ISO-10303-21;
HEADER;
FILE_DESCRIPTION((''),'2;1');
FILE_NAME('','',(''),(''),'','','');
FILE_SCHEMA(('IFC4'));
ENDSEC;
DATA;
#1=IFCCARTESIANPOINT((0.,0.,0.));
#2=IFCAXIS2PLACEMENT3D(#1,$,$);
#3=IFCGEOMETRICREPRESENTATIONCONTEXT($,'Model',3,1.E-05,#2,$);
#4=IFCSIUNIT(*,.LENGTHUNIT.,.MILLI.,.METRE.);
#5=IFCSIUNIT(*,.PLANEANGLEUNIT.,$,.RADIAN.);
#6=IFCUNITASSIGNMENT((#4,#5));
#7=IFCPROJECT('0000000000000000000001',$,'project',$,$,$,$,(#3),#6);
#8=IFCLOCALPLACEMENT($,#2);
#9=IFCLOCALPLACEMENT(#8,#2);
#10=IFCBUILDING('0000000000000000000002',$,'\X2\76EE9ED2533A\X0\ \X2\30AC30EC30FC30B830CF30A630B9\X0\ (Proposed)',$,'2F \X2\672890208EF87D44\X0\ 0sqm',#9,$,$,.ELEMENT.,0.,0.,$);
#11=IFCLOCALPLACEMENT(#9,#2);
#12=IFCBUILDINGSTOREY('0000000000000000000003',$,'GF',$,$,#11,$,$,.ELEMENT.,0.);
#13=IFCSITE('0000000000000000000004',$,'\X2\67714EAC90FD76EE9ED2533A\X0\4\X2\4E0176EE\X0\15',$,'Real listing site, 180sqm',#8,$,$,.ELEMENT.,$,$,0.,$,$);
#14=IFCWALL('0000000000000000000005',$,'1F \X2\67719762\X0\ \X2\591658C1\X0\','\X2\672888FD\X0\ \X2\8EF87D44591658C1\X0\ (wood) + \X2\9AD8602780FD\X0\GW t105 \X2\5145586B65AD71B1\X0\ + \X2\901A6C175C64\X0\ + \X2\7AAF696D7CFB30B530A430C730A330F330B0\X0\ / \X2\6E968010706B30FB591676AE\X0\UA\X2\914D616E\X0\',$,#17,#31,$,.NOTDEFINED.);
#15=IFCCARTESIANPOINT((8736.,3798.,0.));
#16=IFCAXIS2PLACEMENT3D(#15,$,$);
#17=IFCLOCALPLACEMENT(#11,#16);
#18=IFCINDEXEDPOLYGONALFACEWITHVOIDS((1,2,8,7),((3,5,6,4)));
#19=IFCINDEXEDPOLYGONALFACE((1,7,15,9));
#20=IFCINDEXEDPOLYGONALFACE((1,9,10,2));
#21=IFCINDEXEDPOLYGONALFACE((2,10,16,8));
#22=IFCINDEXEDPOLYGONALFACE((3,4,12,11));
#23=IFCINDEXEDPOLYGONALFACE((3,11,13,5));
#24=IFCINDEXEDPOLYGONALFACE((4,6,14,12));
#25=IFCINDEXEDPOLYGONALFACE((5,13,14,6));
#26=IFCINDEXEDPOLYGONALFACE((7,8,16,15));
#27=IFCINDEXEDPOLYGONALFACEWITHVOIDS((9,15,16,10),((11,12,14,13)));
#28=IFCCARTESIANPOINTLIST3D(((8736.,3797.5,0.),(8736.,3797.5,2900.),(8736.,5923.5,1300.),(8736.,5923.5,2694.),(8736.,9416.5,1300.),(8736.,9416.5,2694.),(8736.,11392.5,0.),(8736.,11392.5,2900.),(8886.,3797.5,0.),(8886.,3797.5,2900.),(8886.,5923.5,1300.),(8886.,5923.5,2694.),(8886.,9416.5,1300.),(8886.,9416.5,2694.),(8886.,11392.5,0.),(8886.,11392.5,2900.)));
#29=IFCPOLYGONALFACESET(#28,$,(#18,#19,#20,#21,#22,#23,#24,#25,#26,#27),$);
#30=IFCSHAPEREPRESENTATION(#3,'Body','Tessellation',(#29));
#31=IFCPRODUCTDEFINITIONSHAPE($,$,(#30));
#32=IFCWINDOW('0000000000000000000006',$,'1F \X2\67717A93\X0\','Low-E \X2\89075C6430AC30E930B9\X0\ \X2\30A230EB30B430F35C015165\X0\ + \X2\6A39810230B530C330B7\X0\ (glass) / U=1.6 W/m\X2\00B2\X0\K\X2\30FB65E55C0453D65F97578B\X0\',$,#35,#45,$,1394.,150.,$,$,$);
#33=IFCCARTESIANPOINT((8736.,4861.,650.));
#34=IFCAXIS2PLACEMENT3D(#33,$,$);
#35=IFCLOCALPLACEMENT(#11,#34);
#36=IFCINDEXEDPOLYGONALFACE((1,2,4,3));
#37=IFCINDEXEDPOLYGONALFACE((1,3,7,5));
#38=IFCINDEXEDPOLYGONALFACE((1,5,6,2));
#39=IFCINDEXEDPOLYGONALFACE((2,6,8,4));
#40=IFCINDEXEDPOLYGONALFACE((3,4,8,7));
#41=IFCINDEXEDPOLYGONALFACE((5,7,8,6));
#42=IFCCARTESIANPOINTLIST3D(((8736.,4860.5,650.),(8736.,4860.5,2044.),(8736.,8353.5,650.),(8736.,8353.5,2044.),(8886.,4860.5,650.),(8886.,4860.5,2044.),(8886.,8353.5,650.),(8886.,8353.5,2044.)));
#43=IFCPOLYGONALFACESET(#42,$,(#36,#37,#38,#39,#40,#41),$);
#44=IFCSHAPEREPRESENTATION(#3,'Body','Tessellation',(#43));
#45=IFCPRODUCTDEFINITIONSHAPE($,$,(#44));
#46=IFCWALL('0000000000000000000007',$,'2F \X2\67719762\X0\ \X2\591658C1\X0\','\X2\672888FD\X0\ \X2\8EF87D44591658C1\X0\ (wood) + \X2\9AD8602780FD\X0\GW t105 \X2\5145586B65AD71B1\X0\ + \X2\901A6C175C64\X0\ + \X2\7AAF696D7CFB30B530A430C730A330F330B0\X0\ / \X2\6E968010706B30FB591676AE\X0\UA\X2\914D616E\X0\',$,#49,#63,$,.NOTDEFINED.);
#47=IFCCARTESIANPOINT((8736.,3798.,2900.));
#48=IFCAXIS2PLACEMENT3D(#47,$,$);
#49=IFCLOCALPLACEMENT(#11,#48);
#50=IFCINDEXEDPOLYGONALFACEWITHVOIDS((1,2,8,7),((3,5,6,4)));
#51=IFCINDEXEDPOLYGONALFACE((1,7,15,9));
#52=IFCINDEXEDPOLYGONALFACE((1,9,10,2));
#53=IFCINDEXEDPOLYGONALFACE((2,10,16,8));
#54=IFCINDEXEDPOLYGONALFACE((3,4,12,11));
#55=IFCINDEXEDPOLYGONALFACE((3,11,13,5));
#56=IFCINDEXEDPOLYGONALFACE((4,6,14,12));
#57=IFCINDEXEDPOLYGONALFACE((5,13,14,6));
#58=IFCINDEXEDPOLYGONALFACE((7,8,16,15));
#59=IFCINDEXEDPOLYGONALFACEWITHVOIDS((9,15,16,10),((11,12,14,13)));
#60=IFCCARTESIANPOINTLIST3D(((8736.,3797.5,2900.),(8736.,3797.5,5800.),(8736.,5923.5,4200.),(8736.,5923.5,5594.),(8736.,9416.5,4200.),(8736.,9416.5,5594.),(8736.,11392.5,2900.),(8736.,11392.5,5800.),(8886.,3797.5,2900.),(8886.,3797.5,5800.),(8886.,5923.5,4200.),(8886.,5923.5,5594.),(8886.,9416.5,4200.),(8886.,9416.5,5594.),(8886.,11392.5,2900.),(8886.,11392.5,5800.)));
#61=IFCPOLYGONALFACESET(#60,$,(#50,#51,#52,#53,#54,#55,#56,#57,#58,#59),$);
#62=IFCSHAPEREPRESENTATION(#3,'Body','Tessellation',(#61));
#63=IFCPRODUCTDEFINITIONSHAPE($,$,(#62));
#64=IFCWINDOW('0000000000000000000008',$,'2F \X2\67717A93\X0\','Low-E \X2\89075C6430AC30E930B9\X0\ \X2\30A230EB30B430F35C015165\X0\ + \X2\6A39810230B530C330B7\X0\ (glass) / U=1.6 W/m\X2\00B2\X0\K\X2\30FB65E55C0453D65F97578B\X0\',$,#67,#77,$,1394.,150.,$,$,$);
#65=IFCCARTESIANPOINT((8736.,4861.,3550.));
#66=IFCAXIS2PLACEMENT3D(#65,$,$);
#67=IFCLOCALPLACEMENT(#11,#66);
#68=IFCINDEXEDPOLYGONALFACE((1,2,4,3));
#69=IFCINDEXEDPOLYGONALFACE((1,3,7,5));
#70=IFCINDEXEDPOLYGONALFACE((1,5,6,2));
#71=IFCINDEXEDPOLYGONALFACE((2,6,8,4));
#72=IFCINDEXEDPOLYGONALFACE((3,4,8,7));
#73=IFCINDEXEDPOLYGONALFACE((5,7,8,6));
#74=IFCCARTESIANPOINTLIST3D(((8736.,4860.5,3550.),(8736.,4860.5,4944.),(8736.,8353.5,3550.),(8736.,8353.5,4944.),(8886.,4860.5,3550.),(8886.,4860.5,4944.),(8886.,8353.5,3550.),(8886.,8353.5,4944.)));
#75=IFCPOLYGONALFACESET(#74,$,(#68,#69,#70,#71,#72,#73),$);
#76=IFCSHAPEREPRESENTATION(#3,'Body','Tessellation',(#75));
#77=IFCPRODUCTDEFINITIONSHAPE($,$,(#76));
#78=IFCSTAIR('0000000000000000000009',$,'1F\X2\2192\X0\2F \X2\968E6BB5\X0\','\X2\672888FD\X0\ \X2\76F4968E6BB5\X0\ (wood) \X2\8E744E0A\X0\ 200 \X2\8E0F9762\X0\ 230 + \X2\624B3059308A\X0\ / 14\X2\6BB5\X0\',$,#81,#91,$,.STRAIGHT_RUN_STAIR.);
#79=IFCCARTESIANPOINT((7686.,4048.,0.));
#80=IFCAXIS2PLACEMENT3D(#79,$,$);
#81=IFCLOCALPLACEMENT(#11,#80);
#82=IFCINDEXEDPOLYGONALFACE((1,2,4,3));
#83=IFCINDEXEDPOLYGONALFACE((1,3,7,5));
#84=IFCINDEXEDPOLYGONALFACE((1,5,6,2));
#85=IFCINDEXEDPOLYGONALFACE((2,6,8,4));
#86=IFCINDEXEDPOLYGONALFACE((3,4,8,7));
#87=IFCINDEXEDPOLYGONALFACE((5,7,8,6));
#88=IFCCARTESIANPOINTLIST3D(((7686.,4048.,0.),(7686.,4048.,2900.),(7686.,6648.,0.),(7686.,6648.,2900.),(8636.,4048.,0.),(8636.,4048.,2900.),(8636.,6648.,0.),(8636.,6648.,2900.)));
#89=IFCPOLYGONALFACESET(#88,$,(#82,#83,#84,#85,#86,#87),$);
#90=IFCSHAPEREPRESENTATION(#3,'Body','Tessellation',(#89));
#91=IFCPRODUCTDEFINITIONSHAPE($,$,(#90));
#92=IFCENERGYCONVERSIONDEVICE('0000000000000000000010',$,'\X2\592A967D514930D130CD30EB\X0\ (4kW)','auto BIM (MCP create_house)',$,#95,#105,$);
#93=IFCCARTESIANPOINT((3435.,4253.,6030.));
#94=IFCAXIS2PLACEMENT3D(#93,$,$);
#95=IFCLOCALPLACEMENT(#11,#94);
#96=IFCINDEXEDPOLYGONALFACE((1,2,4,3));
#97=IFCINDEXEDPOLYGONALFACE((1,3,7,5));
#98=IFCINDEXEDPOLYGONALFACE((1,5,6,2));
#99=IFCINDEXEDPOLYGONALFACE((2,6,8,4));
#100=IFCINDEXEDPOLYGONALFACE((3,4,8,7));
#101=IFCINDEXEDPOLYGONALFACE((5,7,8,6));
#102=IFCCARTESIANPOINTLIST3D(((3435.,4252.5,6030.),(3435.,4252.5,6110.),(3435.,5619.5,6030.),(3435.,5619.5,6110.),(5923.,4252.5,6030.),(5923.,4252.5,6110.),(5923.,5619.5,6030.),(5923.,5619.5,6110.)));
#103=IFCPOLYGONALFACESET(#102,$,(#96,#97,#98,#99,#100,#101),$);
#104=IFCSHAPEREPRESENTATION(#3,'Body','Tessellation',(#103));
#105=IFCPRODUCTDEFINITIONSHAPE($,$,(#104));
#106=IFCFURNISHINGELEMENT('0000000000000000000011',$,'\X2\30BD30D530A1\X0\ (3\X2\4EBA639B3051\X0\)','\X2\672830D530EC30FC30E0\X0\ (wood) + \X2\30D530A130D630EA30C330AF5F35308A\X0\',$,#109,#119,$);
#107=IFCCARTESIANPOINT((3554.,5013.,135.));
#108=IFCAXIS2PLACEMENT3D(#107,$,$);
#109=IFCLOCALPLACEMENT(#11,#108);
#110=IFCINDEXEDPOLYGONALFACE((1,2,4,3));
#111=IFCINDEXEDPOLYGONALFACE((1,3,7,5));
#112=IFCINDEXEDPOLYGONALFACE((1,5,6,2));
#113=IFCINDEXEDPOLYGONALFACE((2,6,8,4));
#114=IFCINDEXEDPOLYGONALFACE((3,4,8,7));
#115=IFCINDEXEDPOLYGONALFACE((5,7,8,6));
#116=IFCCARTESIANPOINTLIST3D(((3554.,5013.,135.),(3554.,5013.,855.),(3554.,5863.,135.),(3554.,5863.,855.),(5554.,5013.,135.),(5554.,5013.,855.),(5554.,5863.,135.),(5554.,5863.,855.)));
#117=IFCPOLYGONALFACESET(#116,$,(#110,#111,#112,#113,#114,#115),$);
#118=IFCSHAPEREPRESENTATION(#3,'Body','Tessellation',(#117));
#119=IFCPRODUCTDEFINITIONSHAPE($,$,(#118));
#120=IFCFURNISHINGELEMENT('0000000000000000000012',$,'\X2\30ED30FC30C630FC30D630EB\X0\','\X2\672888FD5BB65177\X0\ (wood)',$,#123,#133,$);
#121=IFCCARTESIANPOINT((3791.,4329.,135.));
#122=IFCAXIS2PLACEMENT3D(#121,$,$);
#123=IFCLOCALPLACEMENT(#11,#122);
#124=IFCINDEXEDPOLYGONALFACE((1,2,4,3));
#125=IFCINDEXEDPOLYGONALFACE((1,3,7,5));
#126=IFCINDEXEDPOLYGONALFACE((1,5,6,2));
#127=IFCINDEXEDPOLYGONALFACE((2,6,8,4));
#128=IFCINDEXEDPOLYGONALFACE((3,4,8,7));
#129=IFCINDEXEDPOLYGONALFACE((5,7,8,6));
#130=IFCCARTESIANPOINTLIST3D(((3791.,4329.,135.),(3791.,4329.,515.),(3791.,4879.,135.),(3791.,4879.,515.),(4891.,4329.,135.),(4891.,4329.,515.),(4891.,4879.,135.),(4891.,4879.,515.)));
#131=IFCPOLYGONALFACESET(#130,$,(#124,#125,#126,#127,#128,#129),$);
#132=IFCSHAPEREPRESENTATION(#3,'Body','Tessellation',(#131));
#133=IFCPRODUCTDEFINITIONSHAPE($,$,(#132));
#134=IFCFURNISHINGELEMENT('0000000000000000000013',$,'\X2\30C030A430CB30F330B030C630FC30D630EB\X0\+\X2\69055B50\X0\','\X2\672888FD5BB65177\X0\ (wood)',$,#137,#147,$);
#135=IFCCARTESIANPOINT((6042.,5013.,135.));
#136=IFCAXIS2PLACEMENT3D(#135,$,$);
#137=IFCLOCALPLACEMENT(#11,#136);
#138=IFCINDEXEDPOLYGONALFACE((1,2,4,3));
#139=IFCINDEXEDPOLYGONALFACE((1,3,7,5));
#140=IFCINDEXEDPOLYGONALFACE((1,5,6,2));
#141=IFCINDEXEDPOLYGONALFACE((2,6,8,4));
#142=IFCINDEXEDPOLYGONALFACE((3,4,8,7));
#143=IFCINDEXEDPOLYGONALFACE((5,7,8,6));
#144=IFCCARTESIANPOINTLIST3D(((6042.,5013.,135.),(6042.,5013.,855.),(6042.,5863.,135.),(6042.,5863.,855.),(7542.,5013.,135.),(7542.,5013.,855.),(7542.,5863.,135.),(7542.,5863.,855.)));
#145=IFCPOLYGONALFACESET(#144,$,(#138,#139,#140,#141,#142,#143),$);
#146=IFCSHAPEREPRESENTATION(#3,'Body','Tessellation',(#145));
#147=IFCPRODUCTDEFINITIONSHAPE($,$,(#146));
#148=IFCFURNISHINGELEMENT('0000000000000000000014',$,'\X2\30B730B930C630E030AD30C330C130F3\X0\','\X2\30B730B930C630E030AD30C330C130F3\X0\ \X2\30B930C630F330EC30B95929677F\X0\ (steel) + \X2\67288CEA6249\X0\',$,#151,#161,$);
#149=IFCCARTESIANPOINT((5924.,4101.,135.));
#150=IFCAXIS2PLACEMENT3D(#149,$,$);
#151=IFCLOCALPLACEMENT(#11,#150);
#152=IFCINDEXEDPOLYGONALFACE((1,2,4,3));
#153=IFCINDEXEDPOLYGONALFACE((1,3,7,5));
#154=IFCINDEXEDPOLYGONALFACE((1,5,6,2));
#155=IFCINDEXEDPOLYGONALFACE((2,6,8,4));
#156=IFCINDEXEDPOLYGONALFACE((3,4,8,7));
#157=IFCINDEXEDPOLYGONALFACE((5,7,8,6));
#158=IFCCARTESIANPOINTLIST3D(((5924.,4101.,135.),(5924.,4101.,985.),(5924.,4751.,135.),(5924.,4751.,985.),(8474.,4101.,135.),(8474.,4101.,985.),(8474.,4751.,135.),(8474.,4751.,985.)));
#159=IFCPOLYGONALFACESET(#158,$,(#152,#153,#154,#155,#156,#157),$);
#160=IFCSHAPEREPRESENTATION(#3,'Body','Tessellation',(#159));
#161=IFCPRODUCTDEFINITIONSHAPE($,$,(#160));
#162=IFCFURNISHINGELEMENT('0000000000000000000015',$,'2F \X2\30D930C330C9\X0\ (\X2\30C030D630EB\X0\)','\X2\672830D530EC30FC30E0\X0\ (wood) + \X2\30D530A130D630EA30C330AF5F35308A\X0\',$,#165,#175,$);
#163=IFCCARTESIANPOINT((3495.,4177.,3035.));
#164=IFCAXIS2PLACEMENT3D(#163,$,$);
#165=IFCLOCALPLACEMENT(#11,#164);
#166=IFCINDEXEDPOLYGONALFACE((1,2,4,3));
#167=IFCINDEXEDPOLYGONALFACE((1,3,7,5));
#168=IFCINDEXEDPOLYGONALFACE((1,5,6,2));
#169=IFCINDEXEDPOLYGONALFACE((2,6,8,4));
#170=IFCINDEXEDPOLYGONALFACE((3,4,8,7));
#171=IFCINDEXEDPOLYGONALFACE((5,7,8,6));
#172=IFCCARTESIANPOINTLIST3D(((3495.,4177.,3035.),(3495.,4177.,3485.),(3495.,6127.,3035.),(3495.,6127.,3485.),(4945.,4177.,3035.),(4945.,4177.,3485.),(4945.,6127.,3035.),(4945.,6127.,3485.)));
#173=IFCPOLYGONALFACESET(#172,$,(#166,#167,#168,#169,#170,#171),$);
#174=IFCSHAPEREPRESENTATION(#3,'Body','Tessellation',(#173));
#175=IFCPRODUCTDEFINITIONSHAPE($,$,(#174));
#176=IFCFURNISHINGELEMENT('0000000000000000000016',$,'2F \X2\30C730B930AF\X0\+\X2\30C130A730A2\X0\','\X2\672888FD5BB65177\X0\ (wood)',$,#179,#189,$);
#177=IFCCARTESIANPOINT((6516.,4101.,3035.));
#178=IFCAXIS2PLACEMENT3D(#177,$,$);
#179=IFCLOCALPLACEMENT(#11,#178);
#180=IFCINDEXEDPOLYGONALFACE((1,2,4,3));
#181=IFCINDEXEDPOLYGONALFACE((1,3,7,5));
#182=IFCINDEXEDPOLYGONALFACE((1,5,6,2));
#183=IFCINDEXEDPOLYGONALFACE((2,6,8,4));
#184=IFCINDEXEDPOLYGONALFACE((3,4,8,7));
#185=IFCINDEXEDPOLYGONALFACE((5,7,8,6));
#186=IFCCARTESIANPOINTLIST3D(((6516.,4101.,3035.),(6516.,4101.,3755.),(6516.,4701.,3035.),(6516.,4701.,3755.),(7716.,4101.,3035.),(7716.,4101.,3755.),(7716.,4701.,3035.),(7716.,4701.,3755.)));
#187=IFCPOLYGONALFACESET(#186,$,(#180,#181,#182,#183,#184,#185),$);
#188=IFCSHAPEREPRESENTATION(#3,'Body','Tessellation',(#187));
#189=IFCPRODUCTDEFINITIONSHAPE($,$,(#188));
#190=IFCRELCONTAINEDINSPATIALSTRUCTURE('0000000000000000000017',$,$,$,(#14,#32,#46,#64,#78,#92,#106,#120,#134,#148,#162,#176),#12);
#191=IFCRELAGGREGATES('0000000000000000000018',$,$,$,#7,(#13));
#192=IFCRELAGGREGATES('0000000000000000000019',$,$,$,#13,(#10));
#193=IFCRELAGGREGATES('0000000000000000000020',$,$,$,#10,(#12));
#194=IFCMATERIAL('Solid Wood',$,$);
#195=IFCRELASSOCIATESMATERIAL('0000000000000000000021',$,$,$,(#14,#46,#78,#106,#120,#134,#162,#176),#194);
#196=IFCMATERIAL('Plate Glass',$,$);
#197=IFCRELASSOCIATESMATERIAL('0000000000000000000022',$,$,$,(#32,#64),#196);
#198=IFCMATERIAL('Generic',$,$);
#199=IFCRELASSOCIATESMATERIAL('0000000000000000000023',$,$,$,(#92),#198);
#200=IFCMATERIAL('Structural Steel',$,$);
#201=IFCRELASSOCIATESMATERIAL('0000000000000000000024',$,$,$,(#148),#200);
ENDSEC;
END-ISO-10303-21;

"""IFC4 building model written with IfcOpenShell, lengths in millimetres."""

from ifc_helpers import new_model, si_unit, frame, frame_2d, origin, place, context, project, spatial, rectangle, extrude, material, element, fill, save


model = new_model("IFC4")

# Units and contexts
model_context = context("Model", 3, precision=1e-05, world=origin())
ifc_project = project(units=[si_unit("LENGTHUNIT", "METRE", prefix="MILLI"), si_unit("PLANEANGLEUNIT", "RADIAN")], contexts=[model_context])

# Site, building, storey
site_placement = place(None, origin())
site = spatial("IfcSite", under=ifc_project, at=site_placement, Name="東京都目黒区4丁目15", ObjectType="Real listing site, 180sqm", CompositionType="ELEMENT", RefElevation=0.0)
building_placement = place(site_placement, origin())
building = spatial("IfcBuilding", under=site, at=building_placement, Name="目黒区 ガレージハウス (Proposed)", ObjectType="2F 木造軸組 0sqm", CompositionType="ELEMENT", ElevationOfRefHeight=0.0, ElevationOfTerrain=0.0)
storey_placement = place(building_placement, origin())
storey = spatial("IfcBuildingStorey", under=building, at=storey_placement, Name="GF", CompositionType="ELEMENT", Elevation=0.0)

# Wall, opening, window
ifc_material_1 = material(Name="Solid Wood")
wall_1_placement = place(storey_placement, frame((8736.0, 3798.0, 0.0)))
wall_1 = element("IfcWall", 1, at=wall_1_placement, inside=storey, material=ifc_material_1, Name="1F 東面 外壁", Description="木製 軸組外壁 (wood) + 高性能GW t105 充填断熱 + 通気層 + 窯業系サイディング / 準耐火・外皮UA配慮", PredefinedType="NOTDEFINED", context=model_context, shape_type="SweptSolid", body=[
    extrude(rectangle(XDim=150.0, YDim=7595.0, at=frame_2d((75.0, 3797.0))), frame((8736.0, 3798.0, 0.0)), (0.0, 0.0, 1.0), 2900.0),
])
opening_1_placement = place(storey_placement, frame((8736.0, 4861.0, 650.0)))
opening_1 = element("IfcOpeningElement", 2, at=opening_1_placement, cuts=wall_1, PredefinedType="NOTDEFINED", context=model_context, shape_type="SweptSolid", body=[
    extrude(rectangle(XDim=150.0, YDim=3493.0, at=frame_2d((75.0, 1746.0))), frame((8736.0, 4861.0, 650.0)), (0.0, 0.0, 1.0), 1394.0),
])
ifc_material_2 = material(Name="Plate Glass")
window_1_placement = place(storey_placement, frame((8736.0, 4861.0, 650.0)))
window_1 = element("IfcWindow", 3, at=window_1_placement, inside=storey, material=ifc_material_2, Name="1F 東窓", Description="Low-E 複層ガラス アルゴン封入 + 樹脂サッシ (glass) / U=1.6 W/m²K・日射取得型", OverallHeight=1394.0, OverallWidth=150.0, context=model_context, shape_type="SweptSolid", body=[
    extrude(rectangle(XDim=150.0, YDim=3493.0, at=frame_2d((75.0, 1746.0))), frame((8736.0, 4861.0, 650.0)), (0.0, 0.0, 1.0), 1394.0),
])
fill(opening_1, window_1)

# Wall, opening, window
wall_2_placement = place(storey_placement, frame((8736.0, 3798.0, 2900.0)))
wall_2 = element("IfcWall", 4, at=wall_2_placement, inside=storey, material=ifc_material_1, Name="2F 東面 外壁", Description="木製 軸組外壁 (wood) + 高性能GW t105 充填断熱 + 通気層 + 窯業系サイディング / 準耐火・外皮UA配慮", PredefinedType="NOTDEFINED", context=model_context, shape_type="SweptSolid", body=[
    extrude(rectangle(XDim=150.0, YDim=7595.0, at=frame_2d((75.0, 3797.0))), frame((8736.0, 3798.0, 2900.0)), (0.0, 0.0, 1.0), 2900.0),
])
opening_2_placement = place(storey_placement, frame((8736.0, 4861.0, 3550.0)))
opening_2 = element("IfcOpeningElement", 5, at=opening_2_placement, cuts=wall_2, PredefinedType="NOTDEFINED", context=model_context, shape_type="SweptSolid", body=[
    extrude(rectangle(XDim=150.0, YDim=3493.0, at=frame_2d((75.0, 1746.0))), frame((8736.0, 4861.0, 3550.0)), (0.0, 0.0, 1.0), 1394.0),
])
window_2_placement = place(storey_placement, frame((8736.0, 4861.0, 3550.0)))
window_2 = element("IfcWindow", 6, at=window_2_placement, inside=storey, material=ifc_material_2, Name="2F 東窓", Description="Low-E 複層ガラス アルゴン封入 + 樹脂サッシ (glass) / U=1.6 W/m²K・日射取得型", OverallHeight=1394.0, OverallWidth=150.0, context=model_context, shape_type="SweptSolid", body=[
    extrude(rectangle(XDim=150.0, YDim=3493.0, at=frame_2d((75.0, 1746.0))), frame((8736.0, 4861.0, 3550.0)), (0.0, 0.0, 1.0), 1394.0),
])
fill(opening_2, window_2)

# Stair
stair_placement = place(storey_placement, frame((7686.0, 4048.0, 0.0)))
element("IfcStair", 7, at=stair_placement, inside=storey, material=ifc_material_1, Name="1F→2F 階段", Description="木製 直階段 (wood) 蹴上 200 踏面 230 + 手すり / 14段", PredefinedType="STRAIGHT_RUN_STAIR", context=model_context, shape_type="SweptSolid", body=[
    extrude(rectangle(XDim=950.0, YDim=2600.0, at=frame_2d((475.0, 1300.0))), frame((7686.0, 4048.0, 0.0)), (0.0, 0.0, 1.0), 2900.0),
])

# Energy conversion device
ifc_material_3 = material(Name="Generic")
energy_conversion_device_placement = place(storey_placement, frame((3435.0, 4253.0, 6030.0)))
element("IfcEnergyConversionDevice", 8, at=energy_conversion_device_placement, inside=storey, material=ifc_material_3, Name="太陽光パネル (4kW)", Description="auto BIM (MCP create_house)", context=model_context, shape_type="SweptSolid", body=[
    extrude(rectangle(XDim=2488.0, YDim=1367.0, at=frame_2d((1244.0, 683.0))), frame((3435.0, 4253.0, 6030.0)), (0.0, 0.0, 1.0), 80.0),
])

# Furnishing elements
furnishing_1_placement = place(storey_placement, frame((3554.0, 5013.0, 135.0)))
element("IfcFurnishingElement", 9, at=furnishing_1_placement, inside=storey, material=ifc_material_1, Name="ソファ (3人掛け)", Description="木フレーム (wood) + ファブリック張り", context=model_context, shape_type="SweptSolid", body=[
    extrude(rectangle(XDim=2000.0, YDim=850.0, at=frame_2d((1000.0, 425.0))), frame((3554.0, 5013.0, 135.0)), (0.0, 0.0, 1.0), 720.0),
])
furnishing_2_placement = place(storey_placement, frame((3791.0, 4329.0, 135.0)))
element("IfcFurnishingElement", 10, at=furnishing_2_placement, inside=storey, material=ifc_material_1, Name="ローテーブル", Description="木製家具 (wood)", context=model_context, shape_type="SweptSolid", body=[
    extrude(rectangle(XDim=1100.0, YDim=550.0, at=frame_2d((550.0, 275.0))), frame((3791.0, 4329.0, 135.0)), (0.0, 0.0, 1.0), 380.0),
])
furnishing_3_placement = place(storey_placement, frame((6042.0, 5013.0, 135.0)))
element("IfcFurnishingElement", 11, at=furnishing_3_placement, inside=storey, material=ifc_material_1, Name="ダイニングテーブル+椅子", Description="木製家具 (wood)", context=model_context, shape_type="SweptSolid", body=[
    extrude(rectangle(XDim=1500.0, YDim=850.0, at=frame_2d((750.0, 425.0))), frame((6042.0, 5013.0, 135.0)), (0.0, 0.0, 1.0), 720.0),
])
ifc_material_4 = material(Name="Structural Steel")
furnishing_4_placement = place(storey_placement, frame((5924.0, 4101.0, 135.0)))
element("IfcFurnishingElement", 12, at=furnishing_4_placement, inside=storey, material=ifc_material_4, Name="システムキッチン", Description="システムキッチン ステンレス天板 (steel) + 木質扉", context=model_context, shape_type="SweptSolid", body=[
    extrude(rectangle(XDim=2550.0, YDim=650.0, at=frame_2d((1275.0, 325.0))), frame((5924.0, 4101.0, 135.0)), (0.0, 0.0, 1.0), 850.0),
])
furnishing_5_placement = place(storey_placement, frame((3495.0, 4177.0, 3035.0)))
element("IfcFurnishingElement", 13, at=furnishing_5_placement, inside=storey, material=ifc_material_1, Name="2F ベッド (ダブル)", Description="木フレーム (wood) + ファブリック張り", context=model_context, shape_type="SweptSolid", body=[
    extrude(rectangle(XDim=1450.0, YDim=1950.0, at=frame_2d((725.0, 975.0))), frame((3495.0, 4177.0, 3035.0)), (0.0, 0.0, 1.0), 450.0),
])
furnishing_6_placement = place(storey_placement, frame((6516.0, 4101.0, 3035.0)))
element("IfcFurnishingElement", 14, at=furnishing_6_placement, inside=storey, material=ifc_material_1, Name="2F デスク+チェア", Description="木製家具 (wood)", context=model_context, shape_type="SweptSolid", body=[
    extrude(rectangle(XDim=1200.0, YDim=600.0, at=frame_2d((600.0, 300.0))), frame((6516.0, 4101.0, 3035.0)), (0.0, 0.0, 1.0), 720.0),
])

save(model, "model.ifc")
